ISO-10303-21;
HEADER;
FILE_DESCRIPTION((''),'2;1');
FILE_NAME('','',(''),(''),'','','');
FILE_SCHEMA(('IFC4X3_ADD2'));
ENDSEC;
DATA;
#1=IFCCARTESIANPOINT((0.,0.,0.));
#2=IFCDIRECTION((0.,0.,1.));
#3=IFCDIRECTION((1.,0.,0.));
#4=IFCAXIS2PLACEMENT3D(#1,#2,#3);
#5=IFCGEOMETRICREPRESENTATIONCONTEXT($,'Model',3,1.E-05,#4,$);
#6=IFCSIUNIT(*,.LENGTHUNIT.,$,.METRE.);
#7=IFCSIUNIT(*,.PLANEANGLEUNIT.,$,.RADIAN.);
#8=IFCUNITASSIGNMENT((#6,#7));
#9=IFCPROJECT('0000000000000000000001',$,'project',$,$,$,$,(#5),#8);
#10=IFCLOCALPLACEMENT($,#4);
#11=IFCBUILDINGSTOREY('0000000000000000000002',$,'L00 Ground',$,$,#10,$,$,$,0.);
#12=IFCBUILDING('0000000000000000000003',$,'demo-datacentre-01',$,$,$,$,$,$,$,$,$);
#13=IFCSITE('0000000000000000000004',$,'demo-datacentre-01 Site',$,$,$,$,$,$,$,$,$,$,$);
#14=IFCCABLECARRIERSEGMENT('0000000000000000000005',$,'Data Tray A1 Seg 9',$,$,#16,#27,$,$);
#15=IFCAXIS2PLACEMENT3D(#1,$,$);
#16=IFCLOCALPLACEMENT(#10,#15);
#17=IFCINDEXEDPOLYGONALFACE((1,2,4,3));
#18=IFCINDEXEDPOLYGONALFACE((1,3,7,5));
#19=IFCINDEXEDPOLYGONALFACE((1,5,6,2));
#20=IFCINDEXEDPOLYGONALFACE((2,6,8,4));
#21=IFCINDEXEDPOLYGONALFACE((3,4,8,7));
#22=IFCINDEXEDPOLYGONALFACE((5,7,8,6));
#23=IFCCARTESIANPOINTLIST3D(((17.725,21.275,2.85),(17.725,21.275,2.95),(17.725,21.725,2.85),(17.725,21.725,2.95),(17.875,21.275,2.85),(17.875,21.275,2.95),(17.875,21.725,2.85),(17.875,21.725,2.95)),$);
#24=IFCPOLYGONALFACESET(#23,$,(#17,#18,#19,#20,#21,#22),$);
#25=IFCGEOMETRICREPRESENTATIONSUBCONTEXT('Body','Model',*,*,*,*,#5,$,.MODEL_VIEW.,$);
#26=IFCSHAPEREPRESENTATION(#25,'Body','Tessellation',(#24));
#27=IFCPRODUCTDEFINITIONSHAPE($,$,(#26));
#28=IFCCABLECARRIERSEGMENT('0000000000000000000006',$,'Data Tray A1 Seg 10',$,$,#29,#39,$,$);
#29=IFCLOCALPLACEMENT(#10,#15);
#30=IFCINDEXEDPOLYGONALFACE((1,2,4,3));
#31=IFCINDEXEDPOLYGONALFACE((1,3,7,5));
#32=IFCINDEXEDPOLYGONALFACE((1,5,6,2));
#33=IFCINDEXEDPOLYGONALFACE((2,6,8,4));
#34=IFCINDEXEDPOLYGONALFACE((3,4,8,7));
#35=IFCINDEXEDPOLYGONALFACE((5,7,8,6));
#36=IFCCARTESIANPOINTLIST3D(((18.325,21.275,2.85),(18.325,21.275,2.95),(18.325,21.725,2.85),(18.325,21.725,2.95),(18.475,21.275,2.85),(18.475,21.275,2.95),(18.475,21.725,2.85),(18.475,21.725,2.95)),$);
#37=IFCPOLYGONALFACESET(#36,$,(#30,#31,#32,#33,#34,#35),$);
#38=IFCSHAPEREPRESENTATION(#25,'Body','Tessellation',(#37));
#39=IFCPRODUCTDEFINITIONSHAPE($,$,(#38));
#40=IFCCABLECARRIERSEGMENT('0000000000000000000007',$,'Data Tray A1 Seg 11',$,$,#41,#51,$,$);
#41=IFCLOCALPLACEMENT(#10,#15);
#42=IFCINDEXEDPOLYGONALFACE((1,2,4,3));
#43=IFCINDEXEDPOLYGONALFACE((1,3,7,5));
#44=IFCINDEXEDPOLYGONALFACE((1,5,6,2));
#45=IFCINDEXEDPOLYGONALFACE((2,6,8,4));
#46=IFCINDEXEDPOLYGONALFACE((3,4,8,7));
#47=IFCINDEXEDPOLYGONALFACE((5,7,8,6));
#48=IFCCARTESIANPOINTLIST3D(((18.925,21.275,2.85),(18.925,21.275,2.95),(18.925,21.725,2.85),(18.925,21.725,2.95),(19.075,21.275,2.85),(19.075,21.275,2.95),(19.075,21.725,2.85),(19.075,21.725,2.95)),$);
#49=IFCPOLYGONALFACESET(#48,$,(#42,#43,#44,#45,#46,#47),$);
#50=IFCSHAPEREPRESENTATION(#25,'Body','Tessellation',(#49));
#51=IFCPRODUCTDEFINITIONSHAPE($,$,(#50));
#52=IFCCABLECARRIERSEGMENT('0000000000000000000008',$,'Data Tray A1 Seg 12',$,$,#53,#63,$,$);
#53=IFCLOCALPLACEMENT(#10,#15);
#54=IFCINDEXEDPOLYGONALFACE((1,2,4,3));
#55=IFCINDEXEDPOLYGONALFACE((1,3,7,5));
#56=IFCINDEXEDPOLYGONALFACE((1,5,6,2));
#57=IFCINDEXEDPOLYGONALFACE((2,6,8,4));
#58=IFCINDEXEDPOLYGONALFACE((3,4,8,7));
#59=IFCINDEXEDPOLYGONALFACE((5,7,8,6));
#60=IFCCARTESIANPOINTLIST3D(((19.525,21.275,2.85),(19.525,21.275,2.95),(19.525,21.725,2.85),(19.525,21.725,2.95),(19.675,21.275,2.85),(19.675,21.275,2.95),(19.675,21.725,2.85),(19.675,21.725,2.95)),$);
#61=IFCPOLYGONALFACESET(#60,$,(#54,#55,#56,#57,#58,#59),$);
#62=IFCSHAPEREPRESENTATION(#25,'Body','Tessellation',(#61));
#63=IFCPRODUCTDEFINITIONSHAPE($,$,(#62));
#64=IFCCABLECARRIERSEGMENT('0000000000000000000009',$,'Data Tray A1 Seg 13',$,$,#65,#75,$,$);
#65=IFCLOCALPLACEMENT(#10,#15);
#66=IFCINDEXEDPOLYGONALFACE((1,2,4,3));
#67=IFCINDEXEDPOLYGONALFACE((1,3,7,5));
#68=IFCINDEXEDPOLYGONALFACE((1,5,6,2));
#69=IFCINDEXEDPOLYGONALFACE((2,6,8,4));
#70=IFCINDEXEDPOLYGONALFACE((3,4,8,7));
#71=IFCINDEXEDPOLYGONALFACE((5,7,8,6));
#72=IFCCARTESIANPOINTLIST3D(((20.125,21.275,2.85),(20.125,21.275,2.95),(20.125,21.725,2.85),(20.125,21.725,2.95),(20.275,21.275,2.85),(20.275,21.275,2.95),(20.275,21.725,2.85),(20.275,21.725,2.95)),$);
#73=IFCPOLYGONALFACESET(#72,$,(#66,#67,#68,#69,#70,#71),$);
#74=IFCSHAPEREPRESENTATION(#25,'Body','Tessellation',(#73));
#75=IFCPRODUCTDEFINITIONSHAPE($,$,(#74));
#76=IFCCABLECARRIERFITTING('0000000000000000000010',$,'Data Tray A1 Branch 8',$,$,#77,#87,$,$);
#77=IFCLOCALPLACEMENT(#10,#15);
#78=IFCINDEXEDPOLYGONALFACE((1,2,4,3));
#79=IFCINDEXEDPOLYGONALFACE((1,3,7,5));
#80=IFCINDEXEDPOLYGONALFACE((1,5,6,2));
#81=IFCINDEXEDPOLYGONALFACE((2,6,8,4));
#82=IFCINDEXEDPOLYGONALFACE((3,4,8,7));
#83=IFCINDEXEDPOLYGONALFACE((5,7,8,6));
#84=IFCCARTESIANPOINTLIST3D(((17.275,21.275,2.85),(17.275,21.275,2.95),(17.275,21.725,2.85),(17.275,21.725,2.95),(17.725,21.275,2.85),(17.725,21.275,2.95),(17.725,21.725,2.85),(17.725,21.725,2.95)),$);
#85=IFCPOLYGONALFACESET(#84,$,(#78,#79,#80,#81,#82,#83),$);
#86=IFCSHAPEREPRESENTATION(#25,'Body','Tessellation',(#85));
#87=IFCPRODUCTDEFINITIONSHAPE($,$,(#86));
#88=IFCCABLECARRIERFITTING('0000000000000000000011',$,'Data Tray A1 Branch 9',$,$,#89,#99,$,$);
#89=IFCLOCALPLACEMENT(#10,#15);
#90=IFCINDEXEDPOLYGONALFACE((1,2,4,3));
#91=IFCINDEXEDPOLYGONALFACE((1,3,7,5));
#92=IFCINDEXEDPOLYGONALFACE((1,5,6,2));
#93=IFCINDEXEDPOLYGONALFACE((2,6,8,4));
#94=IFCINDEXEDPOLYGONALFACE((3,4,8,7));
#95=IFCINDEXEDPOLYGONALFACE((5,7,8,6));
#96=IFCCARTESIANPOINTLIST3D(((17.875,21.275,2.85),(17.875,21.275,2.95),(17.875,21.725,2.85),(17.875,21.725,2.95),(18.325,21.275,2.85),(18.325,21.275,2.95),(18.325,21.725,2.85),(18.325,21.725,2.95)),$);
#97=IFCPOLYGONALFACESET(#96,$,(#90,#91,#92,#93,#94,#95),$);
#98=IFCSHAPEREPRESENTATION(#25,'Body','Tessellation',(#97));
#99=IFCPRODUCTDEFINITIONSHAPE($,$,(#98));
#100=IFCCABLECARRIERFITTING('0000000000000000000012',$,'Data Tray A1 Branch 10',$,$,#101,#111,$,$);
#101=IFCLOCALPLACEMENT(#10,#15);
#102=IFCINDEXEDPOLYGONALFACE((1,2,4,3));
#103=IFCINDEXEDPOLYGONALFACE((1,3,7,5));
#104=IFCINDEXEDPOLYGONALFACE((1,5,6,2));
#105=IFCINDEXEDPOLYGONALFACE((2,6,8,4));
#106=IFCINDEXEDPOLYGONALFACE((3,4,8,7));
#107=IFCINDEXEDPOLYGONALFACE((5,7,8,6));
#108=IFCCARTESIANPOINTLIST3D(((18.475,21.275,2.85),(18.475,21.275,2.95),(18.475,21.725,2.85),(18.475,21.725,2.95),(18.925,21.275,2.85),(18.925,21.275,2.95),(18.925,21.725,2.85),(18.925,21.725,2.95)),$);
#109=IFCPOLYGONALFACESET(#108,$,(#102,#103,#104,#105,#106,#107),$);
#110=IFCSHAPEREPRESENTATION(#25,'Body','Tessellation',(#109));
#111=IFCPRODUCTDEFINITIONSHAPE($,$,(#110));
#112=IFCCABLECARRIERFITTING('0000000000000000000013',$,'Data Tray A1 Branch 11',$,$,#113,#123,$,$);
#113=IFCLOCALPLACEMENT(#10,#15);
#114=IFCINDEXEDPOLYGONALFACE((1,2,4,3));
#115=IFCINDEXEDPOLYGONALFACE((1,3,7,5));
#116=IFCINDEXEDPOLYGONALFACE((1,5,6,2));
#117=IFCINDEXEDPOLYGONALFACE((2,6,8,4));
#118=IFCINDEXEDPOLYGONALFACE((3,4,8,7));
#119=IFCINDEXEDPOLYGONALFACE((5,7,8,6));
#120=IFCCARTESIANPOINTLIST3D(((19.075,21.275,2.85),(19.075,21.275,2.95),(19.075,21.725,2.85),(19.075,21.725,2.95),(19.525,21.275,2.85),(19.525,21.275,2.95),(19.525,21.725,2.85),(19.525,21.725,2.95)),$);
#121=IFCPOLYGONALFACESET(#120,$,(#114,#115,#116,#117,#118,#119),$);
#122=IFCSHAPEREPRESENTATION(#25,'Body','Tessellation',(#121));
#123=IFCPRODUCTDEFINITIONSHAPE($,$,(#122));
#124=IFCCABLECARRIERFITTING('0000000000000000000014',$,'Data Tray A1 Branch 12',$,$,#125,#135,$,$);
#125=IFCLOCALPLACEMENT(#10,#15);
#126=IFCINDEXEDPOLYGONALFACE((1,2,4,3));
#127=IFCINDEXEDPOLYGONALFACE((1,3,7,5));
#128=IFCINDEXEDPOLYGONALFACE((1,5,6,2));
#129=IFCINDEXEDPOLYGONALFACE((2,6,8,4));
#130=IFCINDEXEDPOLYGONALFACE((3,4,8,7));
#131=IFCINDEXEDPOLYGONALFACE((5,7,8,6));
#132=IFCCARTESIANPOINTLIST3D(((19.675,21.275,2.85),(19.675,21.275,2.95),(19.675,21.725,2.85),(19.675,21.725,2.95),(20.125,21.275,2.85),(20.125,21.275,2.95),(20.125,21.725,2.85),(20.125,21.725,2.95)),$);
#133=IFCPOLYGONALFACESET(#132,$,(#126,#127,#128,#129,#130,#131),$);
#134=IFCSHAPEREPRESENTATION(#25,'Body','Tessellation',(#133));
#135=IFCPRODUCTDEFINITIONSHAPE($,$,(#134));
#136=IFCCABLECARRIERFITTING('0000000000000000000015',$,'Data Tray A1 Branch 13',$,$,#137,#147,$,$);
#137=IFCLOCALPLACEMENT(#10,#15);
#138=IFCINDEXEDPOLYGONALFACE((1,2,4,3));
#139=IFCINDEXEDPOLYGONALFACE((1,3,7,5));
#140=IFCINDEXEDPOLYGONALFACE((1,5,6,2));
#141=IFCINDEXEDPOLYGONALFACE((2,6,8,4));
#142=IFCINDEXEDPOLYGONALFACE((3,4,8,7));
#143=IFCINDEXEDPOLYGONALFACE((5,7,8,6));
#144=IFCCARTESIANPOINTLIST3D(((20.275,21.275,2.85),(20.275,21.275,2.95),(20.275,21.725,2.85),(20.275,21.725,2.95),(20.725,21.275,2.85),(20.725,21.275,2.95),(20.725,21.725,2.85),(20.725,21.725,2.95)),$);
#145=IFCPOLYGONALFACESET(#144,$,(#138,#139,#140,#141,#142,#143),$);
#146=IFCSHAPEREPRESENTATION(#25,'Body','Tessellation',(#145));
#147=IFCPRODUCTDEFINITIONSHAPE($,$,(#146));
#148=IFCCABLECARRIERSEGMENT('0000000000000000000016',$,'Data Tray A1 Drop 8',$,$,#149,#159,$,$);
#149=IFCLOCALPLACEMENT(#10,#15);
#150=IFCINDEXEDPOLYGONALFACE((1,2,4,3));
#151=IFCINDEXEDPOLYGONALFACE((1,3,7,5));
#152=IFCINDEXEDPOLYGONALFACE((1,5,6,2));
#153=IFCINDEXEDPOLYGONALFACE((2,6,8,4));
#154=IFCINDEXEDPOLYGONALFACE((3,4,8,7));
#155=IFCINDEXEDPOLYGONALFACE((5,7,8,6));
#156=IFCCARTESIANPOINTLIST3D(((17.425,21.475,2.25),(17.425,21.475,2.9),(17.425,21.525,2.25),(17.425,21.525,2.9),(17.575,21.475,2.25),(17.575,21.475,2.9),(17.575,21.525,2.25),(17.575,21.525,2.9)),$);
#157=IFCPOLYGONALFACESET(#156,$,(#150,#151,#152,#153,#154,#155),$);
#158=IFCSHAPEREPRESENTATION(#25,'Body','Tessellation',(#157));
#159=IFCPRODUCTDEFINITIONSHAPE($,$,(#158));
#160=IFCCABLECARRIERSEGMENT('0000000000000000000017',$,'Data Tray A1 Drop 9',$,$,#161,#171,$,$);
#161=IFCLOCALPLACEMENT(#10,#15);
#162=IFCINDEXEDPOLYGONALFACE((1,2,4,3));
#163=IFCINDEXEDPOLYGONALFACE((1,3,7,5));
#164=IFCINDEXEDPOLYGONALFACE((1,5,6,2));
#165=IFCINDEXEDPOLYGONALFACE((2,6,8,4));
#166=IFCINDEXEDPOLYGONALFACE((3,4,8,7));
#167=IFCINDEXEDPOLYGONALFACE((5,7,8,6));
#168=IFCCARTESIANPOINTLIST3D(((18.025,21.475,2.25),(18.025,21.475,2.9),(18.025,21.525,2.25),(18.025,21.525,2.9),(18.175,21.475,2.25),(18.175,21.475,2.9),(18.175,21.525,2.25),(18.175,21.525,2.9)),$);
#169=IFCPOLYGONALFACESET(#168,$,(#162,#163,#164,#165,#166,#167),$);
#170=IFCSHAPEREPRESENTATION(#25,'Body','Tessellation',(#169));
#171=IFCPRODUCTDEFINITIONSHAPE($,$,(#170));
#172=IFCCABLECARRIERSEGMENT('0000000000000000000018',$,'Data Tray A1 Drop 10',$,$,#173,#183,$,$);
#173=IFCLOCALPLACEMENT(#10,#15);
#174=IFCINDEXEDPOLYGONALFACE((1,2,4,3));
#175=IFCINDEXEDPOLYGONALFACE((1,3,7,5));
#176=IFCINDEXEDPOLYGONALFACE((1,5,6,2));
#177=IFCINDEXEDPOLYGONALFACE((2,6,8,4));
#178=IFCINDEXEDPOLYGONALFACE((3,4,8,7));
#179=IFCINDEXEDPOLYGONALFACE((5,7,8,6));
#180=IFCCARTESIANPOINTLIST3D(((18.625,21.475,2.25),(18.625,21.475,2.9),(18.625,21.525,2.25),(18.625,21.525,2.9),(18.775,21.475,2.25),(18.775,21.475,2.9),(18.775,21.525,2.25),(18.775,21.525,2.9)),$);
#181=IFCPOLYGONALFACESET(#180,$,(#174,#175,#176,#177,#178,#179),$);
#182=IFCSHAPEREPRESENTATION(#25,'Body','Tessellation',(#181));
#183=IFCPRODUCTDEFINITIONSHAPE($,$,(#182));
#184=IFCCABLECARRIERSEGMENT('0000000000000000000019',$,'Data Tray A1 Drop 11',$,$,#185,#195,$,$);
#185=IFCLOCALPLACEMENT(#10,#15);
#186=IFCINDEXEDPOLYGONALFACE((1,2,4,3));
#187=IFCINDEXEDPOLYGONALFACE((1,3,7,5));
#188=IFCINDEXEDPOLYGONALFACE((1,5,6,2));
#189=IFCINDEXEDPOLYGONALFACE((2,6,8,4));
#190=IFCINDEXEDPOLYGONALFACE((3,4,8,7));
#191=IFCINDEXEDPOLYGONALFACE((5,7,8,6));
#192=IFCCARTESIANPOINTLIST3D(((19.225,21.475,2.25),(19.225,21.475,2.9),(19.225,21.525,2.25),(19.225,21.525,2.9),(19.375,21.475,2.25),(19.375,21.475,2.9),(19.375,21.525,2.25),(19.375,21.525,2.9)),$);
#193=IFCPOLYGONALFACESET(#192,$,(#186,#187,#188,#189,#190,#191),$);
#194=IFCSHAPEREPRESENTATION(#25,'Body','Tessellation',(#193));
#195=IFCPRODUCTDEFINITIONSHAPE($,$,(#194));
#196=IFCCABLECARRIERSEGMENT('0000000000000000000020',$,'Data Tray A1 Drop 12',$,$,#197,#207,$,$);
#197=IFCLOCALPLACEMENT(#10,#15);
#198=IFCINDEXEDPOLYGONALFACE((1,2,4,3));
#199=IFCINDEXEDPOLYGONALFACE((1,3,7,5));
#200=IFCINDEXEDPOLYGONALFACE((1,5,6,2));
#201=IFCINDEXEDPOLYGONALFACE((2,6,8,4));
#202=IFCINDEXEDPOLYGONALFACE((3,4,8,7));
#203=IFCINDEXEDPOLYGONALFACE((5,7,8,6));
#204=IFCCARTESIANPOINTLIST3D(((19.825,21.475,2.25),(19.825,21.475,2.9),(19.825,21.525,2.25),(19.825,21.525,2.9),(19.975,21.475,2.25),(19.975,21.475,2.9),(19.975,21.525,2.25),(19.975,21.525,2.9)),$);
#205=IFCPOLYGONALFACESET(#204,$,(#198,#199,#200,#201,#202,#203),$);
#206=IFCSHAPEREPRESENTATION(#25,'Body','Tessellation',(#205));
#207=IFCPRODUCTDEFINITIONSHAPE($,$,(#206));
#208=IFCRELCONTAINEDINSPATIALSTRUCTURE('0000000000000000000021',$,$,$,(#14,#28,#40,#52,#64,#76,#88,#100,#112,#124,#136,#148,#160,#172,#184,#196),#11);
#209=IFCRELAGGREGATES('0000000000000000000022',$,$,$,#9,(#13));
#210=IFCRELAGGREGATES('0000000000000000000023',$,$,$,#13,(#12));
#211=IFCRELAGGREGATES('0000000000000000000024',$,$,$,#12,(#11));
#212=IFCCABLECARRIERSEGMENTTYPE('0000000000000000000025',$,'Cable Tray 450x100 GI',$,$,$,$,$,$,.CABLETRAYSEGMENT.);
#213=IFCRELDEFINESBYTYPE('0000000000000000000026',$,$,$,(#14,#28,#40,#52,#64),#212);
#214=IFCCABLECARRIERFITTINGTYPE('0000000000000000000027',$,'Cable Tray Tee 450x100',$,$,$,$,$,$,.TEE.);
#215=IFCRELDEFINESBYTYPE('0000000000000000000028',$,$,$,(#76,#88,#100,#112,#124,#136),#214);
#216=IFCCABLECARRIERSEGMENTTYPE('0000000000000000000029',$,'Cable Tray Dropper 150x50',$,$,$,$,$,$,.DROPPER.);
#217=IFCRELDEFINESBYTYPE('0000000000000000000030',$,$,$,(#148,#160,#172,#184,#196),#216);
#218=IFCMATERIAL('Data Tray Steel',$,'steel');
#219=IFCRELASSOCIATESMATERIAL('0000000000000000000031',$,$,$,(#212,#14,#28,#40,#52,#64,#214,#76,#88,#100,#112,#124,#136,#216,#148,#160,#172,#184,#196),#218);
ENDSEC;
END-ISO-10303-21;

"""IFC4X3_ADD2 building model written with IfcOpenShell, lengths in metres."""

from ifc_helpers import new_model, si_unit, frame, origin_with_axes, place, context, subcontext, project, spatial, rectangle, extrude, material, type_object, element, save


model = new_model("IFC4X3_ADD2")

# Units and contexts
model_context = context("Model", 3, precision=1e-05, world=origin_with_axes())
body_context = subcontext(model_context, "Body", "Model", "MODEL_VIEW")
ifc_project = project(units=[si_unit("LENGTHUNIT", "METRE"), si_unit("PLANEANGLEUNIT", "RADIAN")], contexts=[model_context])

# Site, building, storey
site = spatial("IfcSite", under=ifc_project, Name="demo-datacentre-01 Site")
building = spatial("IfcBuilding", under=site, Name="demo-datacentre-01")
storey_placement = place(None, origin_with_axes())
storey = spatial("IfcBuildingStorey", under=building, at=storey_placement, Name="L00 Ground", Elevation=0.0)

# Cable carrier segments
ifc_material_1 = material(Name="Data Tray Steel", Category="steel")
cable_carrier_segment_type_1 = type_object("IfcCableCarrierSegmentType", Name="Cable Tray 450x100 GI", PredefinedType="CABLETRAYSEGMENT", material=ifc_material_1)
cable_carrier_segment_1_placement = place(storey_placement, frame((17.725, 21.5, 2.9), z_axis=(1.0, 0.0, 0.0), x_axis=(0.0, 1.0, 0.0)))
element("IfcCableCarrierSegment", 1, at=cable_carrier_segment_1_placement, inside=storey, type_object=cable_carrier_segment_type_1, material=ifc_material_1, Name="Data Tray A1 Seg 9", context=body_context, shape_type="SweptSolid", body=[
    extrude(rectangle(XDim=0.45, YDim=0.1), origin_with_axes(), (0.0, 0.0, 1.0), 0.15),
])
cable_carrier_segment_2_placement = place(storey_placement, frame((18.325, 21.5, 2.9), z_axis=(1.0, 0.0, 0.0), x_axis=(0.0, 1.0, 0.0)))
element("IfcCableCarrierSegment", 2, at=cable_carrier_segment_2_placement, inside=storey, type_object=cable_carrier_segment_type_1, material=ifc_material_1, Name="Data Tray A1 Seg 10", context=body_context, shape_type="SweptSolid", body=[
    extrude(rectangle(XDim=0.45, YDim=0.1), origin_with_axes(), (0.0, 0.0, 1.0), 0.15),
])
cable_carrier_segment_3_placement = place(storey_placement, frame((18.925, 21.5, 2.9), z_axis=(1.0, 0.0, 0.0), x_axis=(0.0, 1.0, 0.0)))
element("IfcCableCarrierSegment", 3, at=cable_carrier_segment_3_placement, inside=storey, type_object=cable_carrier_segment_type_1, material=ifc_material_1, Name="Data Tray A1 Seg 11", context=body_context, shape_type="SweptSolid", body=[
    extrude(rectangle(XDim=0.45, YDim=0.1), origin_with_axes(), (0.0, 0.0, 1.0), 0.15),
])
cable_carrier_segment_4_placement = place(storey_placement, frame((19.525, 21.5, 2.9), z_axis=(1.0, 0.0, 0.0), x_axis=(0.0, 1.0, 0.0)))
element("IfcCableCarrierSegment", 4, at=cable_carrier_segment_4_placement, inside=storey, type_object=cable_carrier_segment_type_1, material=ifc_material_1, Name="Data Tray A1 Seg 12", context=body_context, shape_type="SweptSolid", body=[
    extrude(rectangle(XDim=0.45, YDim=0.1), origin_with_axes(), (0.0, 0.0, 1.0), 0.15),
])
cable_carrier_segment_5_placement = place(storey_placement, frame((20.125, 21.5, 2.9), z_axis=(1.0, 0.0, 0.0), x_axis=(0.0, 1.0, 0.0)))
element("IfcCableCarrierSegment", 5, at=cable_carrier_segment_5_placement, inside=storey, type_object=cable_carrier_segment_type_1, material=ifc_material_1, Name="Data Tray A1 Seg 13", context=body_context, shape_type="SweptSolid", body=[
    extrude(rectangle(XDim=0.45, YDim=0.1), origin_with_axes(), (0.0, 0.0, 1.0), 0.15),
])

# Cable carrier fittings
cable_carrier_fitting_type = type_object("IfcCableCarrierFittingType", Name="Cable Tray Tee 450x100", PredefinedType="TEE", material=ifc_material_1)
for number, where, z_axis, x_axis, name in (
    (6, (17.5, 21.5, 2.85), (0.0, 0.0, 1.0), (1.0, 0.0, 0.0), "Data Tray A1 Branch 8"),
    (7, (18.1, 21.5, 2.85), (0.0, 0.0, 1.0), (1.0, 0.0, 0.0), "Data Tray A1 Branch 9"),
    (8, (18.7, 21.5, 2.85), (0.0, 0.0, 1.0), (1.0, 0.0, 0.0), "Data Tray A1 Branch 10"),
    (9, (19.3, 21.5, 2.85), (0.0, 0.0, 1.0), (1.0, 0.0, 0.0), "Data Tray A1 Branch 11"),
    (10, (19.9, 21.5, 2.85), (0.0, 0.0, 1.0), (1.0, 0.0, 0.0), "Data Tray A1 Branch 12"),
    (11, (20.5, 21.5, 2.85), (0.0, 0.0, 1.0), (1.0, 0.0, 0.0), "Data Tray A1 Branch 13"),
):
    element("IfcCableCarrierFitting", number, at=place(storey_placement, frame(where, z_axis=z_axis, x_axis=x_axis)), inside=storey, type_object=cable_carrier_fitting_type, material=ifc_material_1, Name=name, context=body_context, shape_type="SweptSolid", body=[
        extrude(rectangle(XDim=0.45, YDim=0.45), origin_with_axes(), (0.0, 0.0, 1.0), 0.1),
    ])

# Cable carrier segments
cable_carrier_segment_type_2 = type_object("IfcCableCarrierSegmentType", Name="Cable Tray Dropper 150x50", PredefinedType="DROPPER", material=ifc_material_1)
for number, where, z_axis, x_axis, name in (
    (12, (17.5, 21.5, 2.9), (0.0, 0.0, -1.0), (1.0, 0.0, 0.0), "Data Tray A1 Drop 8"),
    (13, (18.1, 21.5, 2.9), (0.0, 0.0, -1.0), (1.0, 0.0, 0.0), "Data Tray A1 Drop 9"),
    (14, (18.7, 21.5, 2.9), (0.0, 0.0, -1.0), (1.0, 0.0, 0.0), "Data Tray A1 Drop 10"),
    (15, (19.3, 21.5, 2.9), (0.0, 0.0, -1.0), (1.0, 0.0, 0.0), "Data Tray A1 Drop 11"),
    (16, (19.9, 21.5, 2.9), (0.0, 0.0, -1.0), (1.0, 0.0, 0.0), "Data Tray A1 Drop 12"),
):
    element("IfcCableCarrierSegment", number, at=place(storey_placement, frame(where, z_axis=z_axis, x_axis=x_axis)), inside=storey, type_object=cable_carrier_segment_type_2, material=ifc_material_1, Name=name, context=body_context, shape_type="SweptSolid", body=[
        extrude(rectangle(XDim=0.15, YDim=0.05), origin_with_axes(), (0.0, 0.0, 1.0), 0.65),
    ])

save(model, "model.ifc")
